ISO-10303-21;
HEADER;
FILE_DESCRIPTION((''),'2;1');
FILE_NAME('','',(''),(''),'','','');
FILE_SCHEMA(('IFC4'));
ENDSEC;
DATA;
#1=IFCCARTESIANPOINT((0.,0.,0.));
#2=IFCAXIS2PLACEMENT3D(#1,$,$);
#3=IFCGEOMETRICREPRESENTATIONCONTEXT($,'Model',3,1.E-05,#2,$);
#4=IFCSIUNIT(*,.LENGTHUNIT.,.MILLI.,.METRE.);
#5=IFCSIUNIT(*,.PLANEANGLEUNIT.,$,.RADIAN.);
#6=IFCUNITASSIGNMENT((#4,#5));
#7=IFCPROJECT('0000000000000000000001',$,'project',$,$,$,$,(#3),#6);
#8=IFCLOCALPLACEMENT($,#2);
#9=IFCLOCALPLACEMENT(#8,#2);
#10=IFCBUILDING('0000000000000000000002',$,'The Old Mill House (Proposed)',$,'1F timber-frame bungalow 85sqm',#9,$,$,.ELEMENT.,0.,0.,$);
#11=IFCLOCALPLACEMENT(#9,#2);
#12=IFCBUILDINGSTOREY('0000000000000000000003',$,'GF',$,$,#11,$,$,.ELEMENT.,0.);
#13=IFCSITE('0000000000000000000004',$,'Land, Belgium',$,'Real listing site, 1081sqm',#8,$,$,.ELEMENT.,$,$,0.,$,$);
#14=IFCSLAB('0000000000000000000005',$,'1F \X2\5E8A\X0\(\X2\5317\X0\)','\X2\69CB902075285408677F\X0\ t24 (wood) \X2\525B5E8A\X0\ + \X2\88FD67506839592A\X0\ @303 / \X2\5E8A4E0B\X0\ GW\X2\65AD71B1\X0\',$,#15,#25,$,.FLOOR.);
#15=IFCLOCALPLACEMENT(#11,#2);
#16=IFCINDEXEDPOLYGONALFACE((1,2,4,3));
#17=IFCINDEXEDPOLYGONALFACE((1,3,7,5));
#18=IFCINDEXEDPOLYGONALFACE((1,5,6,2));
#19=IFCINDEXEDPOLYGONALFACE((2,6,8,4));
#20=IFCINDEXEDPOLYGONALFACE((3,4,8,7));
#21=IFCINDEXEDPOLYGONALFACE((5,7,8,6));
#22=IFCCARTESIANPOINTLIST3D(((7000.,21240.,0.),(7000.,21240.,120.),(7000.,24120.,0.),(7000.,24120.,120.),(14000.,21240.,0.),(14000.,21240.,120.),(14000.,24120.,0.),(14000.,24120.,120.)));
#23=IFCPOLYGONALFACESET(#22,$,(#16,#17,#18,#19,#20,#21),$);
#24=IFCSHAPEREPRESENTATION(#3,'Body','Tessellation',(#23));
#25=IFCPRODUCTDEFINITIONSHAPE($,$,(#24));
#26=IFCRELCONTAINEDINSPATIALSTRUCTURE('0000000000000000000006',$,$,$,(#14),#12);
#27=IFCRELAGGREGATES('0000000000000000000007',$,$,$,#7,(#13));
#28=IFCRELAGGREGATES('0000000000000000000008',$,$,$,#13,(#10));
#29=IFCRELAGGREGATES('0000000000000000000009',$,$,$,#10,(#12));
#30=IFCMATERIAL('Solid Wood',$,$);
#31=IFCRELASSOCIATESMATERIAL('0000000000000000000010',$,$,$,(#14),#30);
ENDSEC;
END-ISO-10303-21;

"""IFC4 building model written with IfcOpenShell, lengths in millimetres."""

from ifc_helpers import new_model, si_unit, frame, frame_2d, origin, place, context, project, spatial, rectangle, extrude, material, element, save


model = new_model("IFC4")

# Units and contexts
model_context = context("Model", 3, precision=1e-05, world=origin())
ifc_project = project(units=[si_unit("LENGTHUNIT", "METRE", prefix="MILLI"), si_unit("PLANEANGLEUNIT", "RADIAN")], contexts=[model_context])

# Site, building, storey
site_placement = place(None, origin())
site = spatial("IfcSite", under=ifc_project, at=site_placement, Name="Land, Belgium", ObjectType="Real listing site, 1081sqm", CompositionType="ELEMENT", RefElevation=0.0)
building_placement = place(site_placement, origin())
building = spatial("IfcBuilding", under=site, at=building_placement, Name="The Old Mill House (Proposed)", ObjectType="1F timber-frame bungalow 85sqm", CompositionType="ELEMENT", ElevationOfRefHeight=0.0, ElevationOfTerrain=0.0)
storey_placement = place(building_placement, origin())
storey = spatial("IfcBuildingStorey", under=building, at=storey_placement, Name="GF", CompositionType="ELEMENT", Elevation=0.0)

# Slab
ifc_material_1 = material(Name="Solid Wood")
slab_1_placement = place(storey_placement, frame((3500.0, 10620.0, 0.0)))
element("IfcSlab", 1, at=slab_1_placement, inside=storey, material=ifc_material_1, Name="1F 床(北)", Description="構造用合板 t24 (wood) 剛床 + 製材根太 @303 / 床下 GW断熱", PredefinedType="FLOOR", context=model_context, shape_type="SweptSolid", body=[
    extrude(rectangle(XDim=7000.0, YDim=2880.0, at=frame_2d((3500.0, 1440.0))), frame((3500.0, 10620.0, 0.0)), (0.0, 0.0, 1.0), 120.0),
])

save(model, "model.ifc")
